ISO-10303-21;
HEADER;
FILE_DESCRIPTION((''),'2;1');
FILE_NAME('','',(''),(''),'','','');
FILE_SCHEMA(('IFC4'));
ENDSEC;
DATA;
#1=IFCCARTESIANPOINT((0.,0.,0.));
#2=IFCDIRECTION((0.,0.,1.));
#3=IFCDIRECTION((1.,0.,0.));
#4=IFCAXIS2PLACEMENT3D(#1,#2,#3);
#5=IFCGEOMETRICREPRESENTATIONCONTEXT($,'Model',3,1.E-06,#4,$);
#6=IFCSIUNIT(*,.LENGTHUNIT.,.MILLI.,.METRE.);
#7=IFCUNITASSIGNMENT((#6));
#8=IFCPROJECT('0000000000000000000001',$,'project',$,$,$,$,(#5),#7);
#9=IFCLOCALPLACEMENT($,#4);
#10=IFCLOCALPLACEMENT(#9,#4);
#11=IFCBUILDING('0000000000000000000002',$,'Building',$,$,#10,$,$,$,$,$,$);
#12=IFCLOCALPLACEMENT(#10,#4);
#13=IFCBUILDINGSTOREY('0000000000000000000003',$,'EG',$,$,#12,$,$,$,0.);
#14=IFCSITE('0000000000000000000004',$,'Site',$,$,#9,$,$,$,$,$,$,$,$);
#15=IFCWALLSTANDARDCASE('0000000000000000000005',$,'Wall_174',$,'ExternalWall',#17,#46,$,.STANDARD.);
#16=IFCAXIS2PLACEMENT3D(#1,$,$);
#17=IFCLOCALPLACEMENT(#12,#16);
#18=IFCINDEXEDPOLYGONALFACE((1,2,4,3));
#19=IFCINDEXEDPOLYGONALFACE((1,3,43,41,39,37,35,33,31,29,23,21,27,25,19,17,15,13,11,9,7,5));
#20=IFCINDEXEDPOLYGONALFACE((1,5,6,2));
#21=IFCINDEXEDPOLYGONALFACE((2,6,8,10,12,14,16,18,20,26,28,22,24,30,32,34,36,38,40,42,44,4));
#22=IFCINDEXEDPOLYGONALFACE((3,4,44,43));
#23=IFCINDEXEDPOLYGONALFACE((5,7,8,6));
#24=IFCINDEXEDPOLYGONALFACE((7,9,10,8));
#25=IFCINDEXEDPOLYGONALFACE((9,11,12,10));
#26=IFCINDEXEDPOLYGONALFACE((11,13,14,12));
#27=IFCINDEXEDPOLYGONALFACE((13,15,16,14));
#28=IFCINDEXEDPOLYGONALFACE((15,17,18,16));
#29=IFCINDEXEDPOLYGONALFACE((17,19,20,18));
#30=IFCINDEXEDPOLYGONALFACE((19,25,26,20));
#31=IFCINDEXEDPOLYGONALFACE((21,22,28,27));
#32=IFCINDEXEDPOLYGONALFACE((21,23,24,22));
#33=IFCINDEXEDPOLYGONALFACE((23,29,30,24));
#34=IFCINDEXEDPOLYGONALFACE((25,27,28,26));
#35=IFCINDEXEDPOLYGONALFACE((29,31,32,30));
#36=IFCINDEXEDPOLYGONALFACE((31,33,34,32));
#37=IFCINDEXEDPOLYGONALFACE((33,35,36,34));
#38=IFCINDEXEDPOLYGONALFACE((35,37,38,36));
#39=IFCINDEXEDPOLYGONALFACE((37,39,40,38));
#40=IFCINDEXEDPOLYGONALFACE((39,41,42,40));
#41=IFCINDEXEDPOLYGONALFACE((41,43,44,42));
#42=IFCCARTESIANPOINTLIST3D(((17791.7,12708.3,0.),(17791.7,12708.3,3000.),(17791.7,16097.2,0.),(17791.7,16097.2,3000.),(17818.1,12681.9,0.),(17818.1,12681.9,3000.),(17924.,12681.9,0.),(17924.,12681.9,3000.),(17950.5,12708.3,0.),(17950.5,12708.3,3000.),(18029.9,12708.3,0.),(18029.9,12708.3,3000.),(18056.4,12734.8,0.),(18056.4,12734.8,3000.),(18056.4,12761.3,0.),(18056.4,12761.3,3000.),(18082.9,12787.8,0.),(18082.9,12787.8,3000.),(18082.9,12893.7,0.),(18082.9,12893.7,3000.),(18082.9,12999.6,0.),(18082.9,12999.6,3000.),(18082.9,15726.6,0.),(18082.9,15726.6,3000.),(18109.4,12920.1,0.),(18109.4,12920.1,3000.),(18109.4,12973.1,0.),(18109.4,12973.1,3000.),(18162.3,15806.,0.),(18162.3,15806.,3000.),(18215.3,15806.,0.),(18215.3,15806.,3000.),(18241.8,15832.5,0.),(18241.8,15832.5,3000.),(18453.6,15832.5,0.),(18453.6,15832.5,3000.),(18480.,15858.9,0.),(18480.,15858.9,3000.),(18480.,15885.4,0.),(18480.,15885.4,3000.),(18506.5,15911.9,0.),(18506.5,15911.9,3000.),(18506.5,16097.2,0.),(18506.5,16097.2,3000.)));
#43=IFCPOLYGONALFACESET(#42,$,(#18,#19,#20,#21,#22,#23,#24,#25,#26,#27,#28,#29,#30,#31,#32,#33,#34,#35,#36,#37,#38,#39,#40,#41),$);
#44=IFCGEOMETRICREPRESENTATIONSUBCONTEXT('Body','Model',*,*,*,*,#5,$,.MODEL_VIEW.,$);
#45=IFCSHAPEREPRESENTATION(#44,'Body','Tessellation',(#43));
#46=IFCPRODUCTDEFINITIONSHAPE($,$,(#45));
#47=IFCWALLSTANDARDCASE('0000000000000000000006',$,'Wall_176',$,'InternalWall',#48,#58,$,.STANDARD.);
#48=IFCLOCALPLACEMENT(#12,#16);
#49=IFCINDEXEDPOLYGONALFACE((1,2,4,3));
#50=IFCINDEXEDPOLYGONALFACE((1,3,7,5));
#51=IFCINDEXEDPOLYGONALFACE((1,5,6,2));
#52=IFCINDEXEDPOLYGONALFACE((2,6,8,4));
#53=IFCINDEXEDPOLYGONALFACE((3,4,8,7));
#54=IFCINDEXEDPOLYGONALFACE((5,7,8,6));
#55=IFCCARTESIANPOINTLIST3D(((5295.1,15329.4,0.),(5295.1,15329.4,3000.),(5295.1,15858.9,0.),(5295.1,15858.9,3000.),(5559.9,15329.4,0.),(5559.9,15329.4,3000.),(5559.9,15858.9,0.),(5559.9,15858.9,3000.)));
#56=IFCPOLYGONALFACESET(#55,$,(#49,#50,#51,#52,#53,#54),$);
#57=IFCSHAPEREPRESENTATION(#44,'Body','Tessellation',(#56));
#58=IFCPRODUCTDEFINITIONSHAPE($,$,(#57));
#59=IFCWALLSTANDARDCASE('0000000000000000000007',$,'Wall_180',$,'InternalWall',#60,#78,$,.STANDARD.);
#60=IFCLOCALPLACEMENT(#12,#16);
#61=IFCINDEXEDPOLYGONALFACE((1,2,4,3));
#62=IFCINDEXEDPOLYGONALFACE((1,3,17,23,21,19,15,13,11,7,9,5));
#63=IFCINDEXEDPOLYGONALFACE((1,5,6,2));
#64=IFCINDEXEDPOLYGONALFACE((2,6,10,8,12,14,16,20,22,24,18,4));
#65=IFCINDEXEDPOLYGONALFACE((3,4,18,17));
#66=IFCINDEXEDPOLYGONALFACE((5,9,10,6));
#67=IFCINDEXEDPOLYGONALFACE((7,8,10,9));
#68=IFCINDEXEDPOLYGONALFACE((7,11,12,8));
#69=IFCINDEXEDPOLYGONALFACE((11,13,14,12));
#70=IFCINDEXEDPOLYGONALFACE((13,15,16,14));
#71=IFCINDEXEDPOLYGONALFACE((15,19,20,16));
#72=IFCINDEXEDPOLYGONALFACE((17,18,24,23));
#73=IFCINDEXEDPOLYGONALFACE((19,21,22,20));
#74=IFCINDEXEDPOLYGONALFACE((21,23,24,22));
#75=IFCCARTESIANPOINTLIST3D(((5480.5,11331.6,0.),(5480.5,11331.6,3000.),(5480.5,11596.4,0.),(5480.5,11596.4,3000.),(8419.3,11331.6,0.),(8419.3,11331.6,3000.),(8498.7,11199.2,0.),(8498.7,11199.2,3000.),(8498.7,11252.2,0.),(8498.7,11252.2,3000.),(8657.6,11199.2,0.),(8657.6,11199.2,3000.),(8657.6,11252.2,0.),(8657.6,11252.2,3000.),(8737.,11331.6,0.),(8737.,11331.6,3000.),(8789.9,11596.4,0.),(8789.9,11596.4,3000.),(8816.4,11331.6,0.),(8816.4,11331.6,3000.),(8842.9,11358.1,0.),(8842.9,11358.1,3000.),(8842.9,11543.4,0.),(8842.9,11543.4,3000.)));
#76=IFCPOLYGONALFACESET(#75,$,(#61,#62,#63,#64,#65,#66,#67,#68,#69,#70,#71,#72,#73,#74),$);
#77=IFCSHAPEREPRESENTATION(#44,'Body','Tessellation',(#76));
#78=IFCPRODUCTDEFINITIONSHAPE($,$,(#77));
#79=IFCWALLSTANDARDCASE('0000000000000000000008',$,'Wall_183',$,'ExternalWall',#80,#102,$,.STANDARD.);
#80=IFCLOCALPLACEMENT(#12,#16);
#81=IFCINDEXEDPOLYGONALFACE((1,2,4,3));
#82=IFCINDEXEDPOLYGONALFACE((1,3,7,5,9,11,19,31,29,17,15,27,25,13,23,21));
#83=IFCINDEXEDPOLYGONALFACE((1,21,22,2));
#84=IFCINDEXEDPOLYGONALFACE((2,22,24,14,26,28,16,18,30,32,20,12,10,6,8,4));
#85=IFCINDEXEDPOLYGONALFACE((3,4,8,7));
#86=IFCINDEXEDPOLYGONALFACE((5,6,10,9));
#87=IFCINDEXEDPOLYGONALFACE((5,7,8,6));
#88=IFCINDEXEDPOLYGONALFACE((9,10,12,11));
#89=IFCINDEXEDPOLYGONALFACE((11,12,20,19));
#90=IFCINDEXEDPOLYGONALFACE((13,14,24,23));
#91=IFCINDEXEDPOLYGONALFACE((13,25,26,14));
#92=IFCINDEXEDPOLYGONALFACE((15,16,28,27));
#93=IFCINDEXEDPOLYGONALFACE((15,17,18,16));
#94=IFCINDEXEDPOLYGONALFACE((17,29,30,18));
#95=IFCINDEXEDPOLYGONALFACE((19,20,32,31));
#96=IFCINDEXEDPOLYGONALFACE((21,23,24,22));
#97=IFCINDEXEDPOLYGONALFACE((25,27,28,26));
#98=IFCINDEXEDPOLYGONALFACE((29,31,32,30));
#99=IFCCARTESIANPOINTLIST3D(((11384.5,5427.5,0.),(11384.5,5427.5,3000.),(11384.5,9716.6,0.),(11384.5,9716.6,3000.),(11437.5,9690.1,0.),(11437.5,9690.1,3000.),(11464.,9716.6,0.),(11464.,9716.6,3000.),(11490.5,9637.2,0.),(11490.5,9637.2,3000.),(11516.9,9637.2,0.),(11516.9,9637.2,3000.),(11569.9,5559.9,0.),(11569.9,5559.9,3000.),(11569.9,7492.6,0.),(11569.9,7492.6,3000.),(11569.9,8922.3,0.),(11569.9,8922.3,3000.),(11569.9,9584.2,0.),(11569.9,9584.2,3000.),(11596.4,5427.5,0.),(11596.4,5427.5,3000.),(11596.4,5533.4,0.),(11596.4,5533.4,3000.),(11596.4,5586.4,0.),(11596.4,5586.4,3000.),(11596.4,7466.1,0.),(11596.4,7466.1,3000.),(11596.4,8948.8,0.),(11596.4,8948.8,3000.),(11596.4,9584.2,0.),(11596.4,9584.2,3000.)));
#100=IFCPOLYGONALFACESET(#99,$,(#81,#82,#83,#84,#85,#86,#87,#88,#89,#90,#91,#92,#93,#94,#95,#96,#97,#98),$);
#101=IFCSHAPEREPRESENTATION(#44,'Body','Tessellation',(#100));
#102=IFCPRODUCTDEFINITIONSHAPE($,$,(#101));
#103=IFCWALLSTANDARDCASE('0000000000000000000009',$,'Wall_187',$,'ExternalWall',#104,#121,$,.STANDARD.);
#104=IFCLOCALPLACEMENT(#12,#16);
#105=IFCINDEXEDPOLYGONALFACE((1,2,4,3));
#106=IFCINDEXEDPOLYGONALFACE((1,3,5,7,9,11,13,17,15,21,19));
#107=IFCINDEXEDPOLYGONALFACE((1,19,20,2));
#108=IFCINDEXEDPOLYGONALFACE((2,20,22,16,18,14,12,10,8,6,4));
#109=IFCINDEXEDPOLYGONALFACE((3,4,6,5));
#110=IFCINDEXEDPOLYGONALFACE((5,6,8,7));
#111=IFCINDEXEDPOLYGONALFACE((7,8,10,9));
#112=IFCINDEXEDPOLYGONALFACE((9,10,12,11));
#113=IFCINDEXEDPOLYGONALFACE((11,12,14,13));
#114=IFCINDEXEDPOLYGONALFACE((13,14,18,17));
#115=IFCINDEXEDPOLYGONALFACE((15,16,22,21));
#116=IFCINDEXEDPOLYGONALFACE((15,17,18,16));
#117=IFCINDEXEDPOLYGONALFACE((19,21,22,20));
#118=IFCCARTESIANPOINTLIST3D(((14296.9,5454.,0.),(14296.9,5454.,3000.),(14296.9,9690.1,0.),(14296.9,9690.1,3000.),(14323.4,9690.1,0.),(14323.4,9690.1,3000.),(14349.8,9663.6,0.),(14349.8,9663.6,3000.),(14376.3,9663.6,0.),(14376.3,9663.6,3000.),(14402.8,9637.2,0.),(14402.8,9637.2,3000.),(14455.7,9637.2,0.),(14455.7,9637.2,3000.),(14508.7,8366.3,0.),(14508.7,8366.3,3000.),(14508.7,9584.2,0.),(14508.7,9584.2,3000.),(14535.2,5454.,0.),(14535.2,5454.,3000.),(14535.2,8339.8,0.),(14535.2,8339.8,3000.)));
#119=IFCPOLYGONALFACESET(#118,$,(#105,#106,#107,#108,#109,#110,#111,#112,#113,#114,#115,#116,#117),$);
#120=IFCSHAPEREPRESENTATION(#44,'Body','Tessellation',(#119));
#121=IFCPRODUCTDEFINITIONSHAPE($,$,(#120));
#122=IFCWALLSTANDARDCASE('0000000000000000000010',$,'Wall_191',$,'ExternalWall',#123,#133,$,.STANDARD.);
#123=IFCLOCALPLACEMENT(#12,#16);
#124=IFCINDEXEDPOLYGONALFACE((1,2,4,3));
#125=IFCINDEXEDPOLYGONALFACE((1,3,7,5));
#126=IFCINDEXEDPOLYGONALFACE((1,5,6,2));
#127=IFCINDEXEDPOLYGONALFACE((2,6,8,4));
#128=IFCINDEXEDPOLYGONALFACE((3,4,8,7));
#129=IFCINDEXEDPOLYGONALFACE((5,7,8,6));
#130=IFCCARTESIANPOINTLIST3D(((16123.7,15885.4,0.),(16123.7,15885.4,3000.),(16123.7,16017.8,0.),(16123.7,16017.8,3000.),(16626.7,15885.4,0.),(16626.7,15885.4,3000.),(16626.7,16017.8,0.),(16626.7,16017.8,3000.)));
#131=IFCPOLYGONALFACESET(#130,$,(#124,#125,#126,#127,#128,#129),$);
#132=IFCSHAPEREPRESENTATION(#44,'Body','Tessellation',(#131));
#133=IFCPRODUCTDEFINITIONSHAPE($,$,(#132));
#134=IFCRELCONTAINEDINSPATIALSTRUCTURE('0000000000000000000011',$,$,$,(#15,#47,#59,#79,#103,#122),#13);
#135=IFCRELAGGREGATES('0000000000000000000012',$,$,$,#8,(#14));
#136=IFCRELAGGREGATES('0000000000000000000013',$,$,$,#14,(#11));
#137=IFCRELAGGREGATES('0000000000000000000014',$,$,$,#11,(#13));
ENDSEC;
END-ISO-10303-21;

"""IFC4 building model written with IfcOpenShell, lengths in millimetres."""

from ifc_helpers import new_model, si_unit, frame, origin_with_axes, place, context, subcontext, project, spatial, polyline, outline, extrude, element, save


model = new_model("IFC4")

# Units and contexts
model_context = context("Model", 3, precision=1e-06, world=origin_with_axes())
body_context = subcontext(model_context, "Body", "Model", "MODEL_VIEW")
ifc_project = project(units=[si_unit("LENGTHUNIT", "METRE", prefix="MILLI")], contexts=[model_context])

# Site, building, storey
site_placement = place(None, origin_with_axes())
site = spatial("IfcSite", under=ifc_project, at=site_placement, Name="Site")
building_placement = place(site_placement, origin_with_axes())
building = spatial("IfcBuilding", under=site, at=building_placement, Name="Building")
storey_placement = place(building_placement, origin_with_axes())
storey = spatial("IfcBuildingStorey", under=building, at=storey_placement, Name="EG", Elevation=0.0)

# Walls
for number, where, z_axis, x_axis, name in (
    (1, (0.0, 0.0, 0.0), (0.0, 0.0, 1.0), (1.0, 0.0, 0.0), "Wall_174"),
):
    element("IfcWallStandardCase", number, at=place(storey_placement, frame(where, z_axis=z_axis, x_axis=x_axis)), inside=storey, Name=name, ObjectType="ExternalWall", PredefinedType="STANDARD", context=body_context, shape_type="SweptSolid", body=[
        extrude(outline(polyline([(17818.1, 12681.9, 0.0), (17791.7, 12708.3, 0.0), (17791.7, 16097.2, 0.0), (18506.5, 16097.2, 0.0), (18506.5, 15911.9, 0.0), (18480.0, 15885.4, 0.0), (18480.0, 15858.9, 0.0), (18453.6, 15832.5, 0.0), (18241.8, 15832.5, 0.0), (18215.3, 15806.0, 0.0), (18162.3, 15806.0, 0.0), (18082.9, 15726.6, 0.0), (18082.9, 12999.6, 0.0), (18109.4, 12973.1, 0.0), (18109.4, 12920.1, 0.0), (18082.9, 12893.7, 0.0), (18082.9, 12787.8, 0.0), (18056.4, 12761.3, 0.0), (18056.4, 12734.8, 0.0), (18029.9, 12708.3, 0.0), (17950.5, 12708.3, 0.0), (17924.0, 12681.9, 0.0), (17818.1, 12681.9, 0.0)])), origin_with_axes(), (0.0, 0.0, 1.0), 3000.0),
    ])
for number, where, z_axis, x_axis, name in (
    (2, (0.0, 0.0, 0.0), (0.0, 0.0, 1.0), (1.0, 0.0, 0.0), "Wall_176"),
):
    element("IfcWallStandardCase", number, at=place(storey_placement, frame(where, z_axis=z_axis, x_axis=x_axis)), inside=storey, Name=name, ObjectType="InternalWall", PredefinedType="STANDARD", context=body_context, shape_type="SweptSolid", body=[
        extrude(outline(polyline([(5295.1, 15329.4, 0.0), (5295.1, 15858.9, 0.0), (5559.9, 15858.9, 0.0), (5559.9, 15329.4, 0.0), (5295.1, 15329.4, 0.0)])), origin_with_axes(), (0.0, 0.0, 1.0), 3000.0),
    ])
for number, where, z_axis, x_axis, name in (
    (3, (0.0, 0.0, 0.0), (0.0, 0.0, 1.0), (1.0, 0.0, 0.0), "Wall_180"),
):
    element("IfcWallStandardCase", number, at=place(storey_placement, frame(where, z_axis=z_axis, x_axis=x_axis)), inside=storey, Name=name, ObjectType="InternalWall", PredefinedType="STANDARD", context=body_context, shape_type="SweptSolid", body=[
        extrude(outline(polyline([(8498.7, 11199.2, 0.0), (8498.7, 11252.2, 0.0), (8419.3, 11331.6, 0.0), (5480.5, 11331.6, 0.0), (5480.5, 11596.4, 0.0), (8789.9, 11596.4, 0.0), (8842.9, 11543.4, 0.0), (8842.9, 11358.1, 0.0), (8816.4, 11331.6, 0.0), (8737.0, 11331.6, 0.0), (8657.6, 11252.2, 0.0), (8657.6, 11199.2, 0.0), (8498.7, 11199.2, 0.0)])), origin_with_axes(), (0.0, 0.0, 1.0), 3000.0),
    ])
for number, where, z_axis, x_axis, name in (
    (4, (0.0, 0.0, 0.0), (0.0, 0.0, 1.0), (1.0, 0.0, 0.0), "Wall_183"),
):
    element("IfcWallStandardCase", number, at=place(storey_placement, frame(where, z_axis=z_axis, x_axis=x_axis)), inside=storey, Name=name, ObjectType="ExternalWall", PredefinedType="STANDARD", context=body_context, shape_type="SweptSolid", body=[
        extrude(outline(polyline([(11384.5, 5427.5, 0.0), (11384.5, 9716.6, 0.0), (11464.0, 9716.6, 0.0), (11437.5, 9690.1, 0.0), (11490.5, 9637.2, 0.0), (11516.9, 9637.2, 0.0), (11569.9, 9584.2, 0.0), (11596.4, 9584.2, 0.0), (11596.4, 8948.8, 0.0), (11569.9, 8922.3, 0.0), (11569.9, 7492.6, 0.0), (11596.4, 7466.1, 0.0), (11596.4, 5586.4, 0.0), (11569.9, 5559.9, 0.0), (11596.4, 5533.4, 0.0), (11596.4, 5427.5, 0.0), (11384.5, 5427.5, 0.0)])), origin_with_axes(), (0.0, 0.0, 1.0), 3000.0),
    ])
for number, where, z_axis, x_axis, name in (
    (5, (0.0, 0.0, 0.0), (0.0, 0.0, 1.0), (1.0, 0.0, 0.0), "Wall_187"),
):
    element("IfcWallStandardCase", number, at=place(storey_placement, frame(where, z_axis=z_axis, x_axis=x_axis)), inside=storey, Name=name, ObjectType="ExternalWall", PredefinedType="STANDARD", context=body_context, shape_type="SweptSolid", body=[
        extrude(outline(polyline([(14296.9, 5454.0, 0.0), (14296.9, 9690.1, 0.0), (14323.4, 9690.1, 0.0), (14349.8, 9663.6, 0.0), (14376.3, 9663.6, 0.0), (14402.8, 9637.2, 0.0), (14455.7, 9637.2, 0.0), (14508.7, 9584.2, 0.0), (14508.7, 8366.3, 0.0), (14535.2, 8339.8, 0.0), (14535.2, 5454.0, 0.0), (14296.9, 5454.0, 0.0)])), origin_with_axes(), (0.0, 0.0, 1.0), 3000.0),
    ])
wall_1_placement = place(storey_placement, origin_with_axes())
element("IfcWallStandardCase", 6, at=wall_1_placement, inside=storey, Name="Wall_191", ObjectType="ExternalWall", PredefinedType="STANDARD", context=body_context, shape_type="SweptSolid", body=[
    extrude(outline(polyline([(16123.7, 15885.4, 0.0), (16123.7, 16017.8, 0.0), (16626.7, 16017.8, 0.0), (16626.7, 15885.4, 0.0), (16123.7, 15885.4, 0.0)])), origin_with_axes(), (0.0, 0.0, 1.0), 3000.0),
])

save(model, "model.ifc")
